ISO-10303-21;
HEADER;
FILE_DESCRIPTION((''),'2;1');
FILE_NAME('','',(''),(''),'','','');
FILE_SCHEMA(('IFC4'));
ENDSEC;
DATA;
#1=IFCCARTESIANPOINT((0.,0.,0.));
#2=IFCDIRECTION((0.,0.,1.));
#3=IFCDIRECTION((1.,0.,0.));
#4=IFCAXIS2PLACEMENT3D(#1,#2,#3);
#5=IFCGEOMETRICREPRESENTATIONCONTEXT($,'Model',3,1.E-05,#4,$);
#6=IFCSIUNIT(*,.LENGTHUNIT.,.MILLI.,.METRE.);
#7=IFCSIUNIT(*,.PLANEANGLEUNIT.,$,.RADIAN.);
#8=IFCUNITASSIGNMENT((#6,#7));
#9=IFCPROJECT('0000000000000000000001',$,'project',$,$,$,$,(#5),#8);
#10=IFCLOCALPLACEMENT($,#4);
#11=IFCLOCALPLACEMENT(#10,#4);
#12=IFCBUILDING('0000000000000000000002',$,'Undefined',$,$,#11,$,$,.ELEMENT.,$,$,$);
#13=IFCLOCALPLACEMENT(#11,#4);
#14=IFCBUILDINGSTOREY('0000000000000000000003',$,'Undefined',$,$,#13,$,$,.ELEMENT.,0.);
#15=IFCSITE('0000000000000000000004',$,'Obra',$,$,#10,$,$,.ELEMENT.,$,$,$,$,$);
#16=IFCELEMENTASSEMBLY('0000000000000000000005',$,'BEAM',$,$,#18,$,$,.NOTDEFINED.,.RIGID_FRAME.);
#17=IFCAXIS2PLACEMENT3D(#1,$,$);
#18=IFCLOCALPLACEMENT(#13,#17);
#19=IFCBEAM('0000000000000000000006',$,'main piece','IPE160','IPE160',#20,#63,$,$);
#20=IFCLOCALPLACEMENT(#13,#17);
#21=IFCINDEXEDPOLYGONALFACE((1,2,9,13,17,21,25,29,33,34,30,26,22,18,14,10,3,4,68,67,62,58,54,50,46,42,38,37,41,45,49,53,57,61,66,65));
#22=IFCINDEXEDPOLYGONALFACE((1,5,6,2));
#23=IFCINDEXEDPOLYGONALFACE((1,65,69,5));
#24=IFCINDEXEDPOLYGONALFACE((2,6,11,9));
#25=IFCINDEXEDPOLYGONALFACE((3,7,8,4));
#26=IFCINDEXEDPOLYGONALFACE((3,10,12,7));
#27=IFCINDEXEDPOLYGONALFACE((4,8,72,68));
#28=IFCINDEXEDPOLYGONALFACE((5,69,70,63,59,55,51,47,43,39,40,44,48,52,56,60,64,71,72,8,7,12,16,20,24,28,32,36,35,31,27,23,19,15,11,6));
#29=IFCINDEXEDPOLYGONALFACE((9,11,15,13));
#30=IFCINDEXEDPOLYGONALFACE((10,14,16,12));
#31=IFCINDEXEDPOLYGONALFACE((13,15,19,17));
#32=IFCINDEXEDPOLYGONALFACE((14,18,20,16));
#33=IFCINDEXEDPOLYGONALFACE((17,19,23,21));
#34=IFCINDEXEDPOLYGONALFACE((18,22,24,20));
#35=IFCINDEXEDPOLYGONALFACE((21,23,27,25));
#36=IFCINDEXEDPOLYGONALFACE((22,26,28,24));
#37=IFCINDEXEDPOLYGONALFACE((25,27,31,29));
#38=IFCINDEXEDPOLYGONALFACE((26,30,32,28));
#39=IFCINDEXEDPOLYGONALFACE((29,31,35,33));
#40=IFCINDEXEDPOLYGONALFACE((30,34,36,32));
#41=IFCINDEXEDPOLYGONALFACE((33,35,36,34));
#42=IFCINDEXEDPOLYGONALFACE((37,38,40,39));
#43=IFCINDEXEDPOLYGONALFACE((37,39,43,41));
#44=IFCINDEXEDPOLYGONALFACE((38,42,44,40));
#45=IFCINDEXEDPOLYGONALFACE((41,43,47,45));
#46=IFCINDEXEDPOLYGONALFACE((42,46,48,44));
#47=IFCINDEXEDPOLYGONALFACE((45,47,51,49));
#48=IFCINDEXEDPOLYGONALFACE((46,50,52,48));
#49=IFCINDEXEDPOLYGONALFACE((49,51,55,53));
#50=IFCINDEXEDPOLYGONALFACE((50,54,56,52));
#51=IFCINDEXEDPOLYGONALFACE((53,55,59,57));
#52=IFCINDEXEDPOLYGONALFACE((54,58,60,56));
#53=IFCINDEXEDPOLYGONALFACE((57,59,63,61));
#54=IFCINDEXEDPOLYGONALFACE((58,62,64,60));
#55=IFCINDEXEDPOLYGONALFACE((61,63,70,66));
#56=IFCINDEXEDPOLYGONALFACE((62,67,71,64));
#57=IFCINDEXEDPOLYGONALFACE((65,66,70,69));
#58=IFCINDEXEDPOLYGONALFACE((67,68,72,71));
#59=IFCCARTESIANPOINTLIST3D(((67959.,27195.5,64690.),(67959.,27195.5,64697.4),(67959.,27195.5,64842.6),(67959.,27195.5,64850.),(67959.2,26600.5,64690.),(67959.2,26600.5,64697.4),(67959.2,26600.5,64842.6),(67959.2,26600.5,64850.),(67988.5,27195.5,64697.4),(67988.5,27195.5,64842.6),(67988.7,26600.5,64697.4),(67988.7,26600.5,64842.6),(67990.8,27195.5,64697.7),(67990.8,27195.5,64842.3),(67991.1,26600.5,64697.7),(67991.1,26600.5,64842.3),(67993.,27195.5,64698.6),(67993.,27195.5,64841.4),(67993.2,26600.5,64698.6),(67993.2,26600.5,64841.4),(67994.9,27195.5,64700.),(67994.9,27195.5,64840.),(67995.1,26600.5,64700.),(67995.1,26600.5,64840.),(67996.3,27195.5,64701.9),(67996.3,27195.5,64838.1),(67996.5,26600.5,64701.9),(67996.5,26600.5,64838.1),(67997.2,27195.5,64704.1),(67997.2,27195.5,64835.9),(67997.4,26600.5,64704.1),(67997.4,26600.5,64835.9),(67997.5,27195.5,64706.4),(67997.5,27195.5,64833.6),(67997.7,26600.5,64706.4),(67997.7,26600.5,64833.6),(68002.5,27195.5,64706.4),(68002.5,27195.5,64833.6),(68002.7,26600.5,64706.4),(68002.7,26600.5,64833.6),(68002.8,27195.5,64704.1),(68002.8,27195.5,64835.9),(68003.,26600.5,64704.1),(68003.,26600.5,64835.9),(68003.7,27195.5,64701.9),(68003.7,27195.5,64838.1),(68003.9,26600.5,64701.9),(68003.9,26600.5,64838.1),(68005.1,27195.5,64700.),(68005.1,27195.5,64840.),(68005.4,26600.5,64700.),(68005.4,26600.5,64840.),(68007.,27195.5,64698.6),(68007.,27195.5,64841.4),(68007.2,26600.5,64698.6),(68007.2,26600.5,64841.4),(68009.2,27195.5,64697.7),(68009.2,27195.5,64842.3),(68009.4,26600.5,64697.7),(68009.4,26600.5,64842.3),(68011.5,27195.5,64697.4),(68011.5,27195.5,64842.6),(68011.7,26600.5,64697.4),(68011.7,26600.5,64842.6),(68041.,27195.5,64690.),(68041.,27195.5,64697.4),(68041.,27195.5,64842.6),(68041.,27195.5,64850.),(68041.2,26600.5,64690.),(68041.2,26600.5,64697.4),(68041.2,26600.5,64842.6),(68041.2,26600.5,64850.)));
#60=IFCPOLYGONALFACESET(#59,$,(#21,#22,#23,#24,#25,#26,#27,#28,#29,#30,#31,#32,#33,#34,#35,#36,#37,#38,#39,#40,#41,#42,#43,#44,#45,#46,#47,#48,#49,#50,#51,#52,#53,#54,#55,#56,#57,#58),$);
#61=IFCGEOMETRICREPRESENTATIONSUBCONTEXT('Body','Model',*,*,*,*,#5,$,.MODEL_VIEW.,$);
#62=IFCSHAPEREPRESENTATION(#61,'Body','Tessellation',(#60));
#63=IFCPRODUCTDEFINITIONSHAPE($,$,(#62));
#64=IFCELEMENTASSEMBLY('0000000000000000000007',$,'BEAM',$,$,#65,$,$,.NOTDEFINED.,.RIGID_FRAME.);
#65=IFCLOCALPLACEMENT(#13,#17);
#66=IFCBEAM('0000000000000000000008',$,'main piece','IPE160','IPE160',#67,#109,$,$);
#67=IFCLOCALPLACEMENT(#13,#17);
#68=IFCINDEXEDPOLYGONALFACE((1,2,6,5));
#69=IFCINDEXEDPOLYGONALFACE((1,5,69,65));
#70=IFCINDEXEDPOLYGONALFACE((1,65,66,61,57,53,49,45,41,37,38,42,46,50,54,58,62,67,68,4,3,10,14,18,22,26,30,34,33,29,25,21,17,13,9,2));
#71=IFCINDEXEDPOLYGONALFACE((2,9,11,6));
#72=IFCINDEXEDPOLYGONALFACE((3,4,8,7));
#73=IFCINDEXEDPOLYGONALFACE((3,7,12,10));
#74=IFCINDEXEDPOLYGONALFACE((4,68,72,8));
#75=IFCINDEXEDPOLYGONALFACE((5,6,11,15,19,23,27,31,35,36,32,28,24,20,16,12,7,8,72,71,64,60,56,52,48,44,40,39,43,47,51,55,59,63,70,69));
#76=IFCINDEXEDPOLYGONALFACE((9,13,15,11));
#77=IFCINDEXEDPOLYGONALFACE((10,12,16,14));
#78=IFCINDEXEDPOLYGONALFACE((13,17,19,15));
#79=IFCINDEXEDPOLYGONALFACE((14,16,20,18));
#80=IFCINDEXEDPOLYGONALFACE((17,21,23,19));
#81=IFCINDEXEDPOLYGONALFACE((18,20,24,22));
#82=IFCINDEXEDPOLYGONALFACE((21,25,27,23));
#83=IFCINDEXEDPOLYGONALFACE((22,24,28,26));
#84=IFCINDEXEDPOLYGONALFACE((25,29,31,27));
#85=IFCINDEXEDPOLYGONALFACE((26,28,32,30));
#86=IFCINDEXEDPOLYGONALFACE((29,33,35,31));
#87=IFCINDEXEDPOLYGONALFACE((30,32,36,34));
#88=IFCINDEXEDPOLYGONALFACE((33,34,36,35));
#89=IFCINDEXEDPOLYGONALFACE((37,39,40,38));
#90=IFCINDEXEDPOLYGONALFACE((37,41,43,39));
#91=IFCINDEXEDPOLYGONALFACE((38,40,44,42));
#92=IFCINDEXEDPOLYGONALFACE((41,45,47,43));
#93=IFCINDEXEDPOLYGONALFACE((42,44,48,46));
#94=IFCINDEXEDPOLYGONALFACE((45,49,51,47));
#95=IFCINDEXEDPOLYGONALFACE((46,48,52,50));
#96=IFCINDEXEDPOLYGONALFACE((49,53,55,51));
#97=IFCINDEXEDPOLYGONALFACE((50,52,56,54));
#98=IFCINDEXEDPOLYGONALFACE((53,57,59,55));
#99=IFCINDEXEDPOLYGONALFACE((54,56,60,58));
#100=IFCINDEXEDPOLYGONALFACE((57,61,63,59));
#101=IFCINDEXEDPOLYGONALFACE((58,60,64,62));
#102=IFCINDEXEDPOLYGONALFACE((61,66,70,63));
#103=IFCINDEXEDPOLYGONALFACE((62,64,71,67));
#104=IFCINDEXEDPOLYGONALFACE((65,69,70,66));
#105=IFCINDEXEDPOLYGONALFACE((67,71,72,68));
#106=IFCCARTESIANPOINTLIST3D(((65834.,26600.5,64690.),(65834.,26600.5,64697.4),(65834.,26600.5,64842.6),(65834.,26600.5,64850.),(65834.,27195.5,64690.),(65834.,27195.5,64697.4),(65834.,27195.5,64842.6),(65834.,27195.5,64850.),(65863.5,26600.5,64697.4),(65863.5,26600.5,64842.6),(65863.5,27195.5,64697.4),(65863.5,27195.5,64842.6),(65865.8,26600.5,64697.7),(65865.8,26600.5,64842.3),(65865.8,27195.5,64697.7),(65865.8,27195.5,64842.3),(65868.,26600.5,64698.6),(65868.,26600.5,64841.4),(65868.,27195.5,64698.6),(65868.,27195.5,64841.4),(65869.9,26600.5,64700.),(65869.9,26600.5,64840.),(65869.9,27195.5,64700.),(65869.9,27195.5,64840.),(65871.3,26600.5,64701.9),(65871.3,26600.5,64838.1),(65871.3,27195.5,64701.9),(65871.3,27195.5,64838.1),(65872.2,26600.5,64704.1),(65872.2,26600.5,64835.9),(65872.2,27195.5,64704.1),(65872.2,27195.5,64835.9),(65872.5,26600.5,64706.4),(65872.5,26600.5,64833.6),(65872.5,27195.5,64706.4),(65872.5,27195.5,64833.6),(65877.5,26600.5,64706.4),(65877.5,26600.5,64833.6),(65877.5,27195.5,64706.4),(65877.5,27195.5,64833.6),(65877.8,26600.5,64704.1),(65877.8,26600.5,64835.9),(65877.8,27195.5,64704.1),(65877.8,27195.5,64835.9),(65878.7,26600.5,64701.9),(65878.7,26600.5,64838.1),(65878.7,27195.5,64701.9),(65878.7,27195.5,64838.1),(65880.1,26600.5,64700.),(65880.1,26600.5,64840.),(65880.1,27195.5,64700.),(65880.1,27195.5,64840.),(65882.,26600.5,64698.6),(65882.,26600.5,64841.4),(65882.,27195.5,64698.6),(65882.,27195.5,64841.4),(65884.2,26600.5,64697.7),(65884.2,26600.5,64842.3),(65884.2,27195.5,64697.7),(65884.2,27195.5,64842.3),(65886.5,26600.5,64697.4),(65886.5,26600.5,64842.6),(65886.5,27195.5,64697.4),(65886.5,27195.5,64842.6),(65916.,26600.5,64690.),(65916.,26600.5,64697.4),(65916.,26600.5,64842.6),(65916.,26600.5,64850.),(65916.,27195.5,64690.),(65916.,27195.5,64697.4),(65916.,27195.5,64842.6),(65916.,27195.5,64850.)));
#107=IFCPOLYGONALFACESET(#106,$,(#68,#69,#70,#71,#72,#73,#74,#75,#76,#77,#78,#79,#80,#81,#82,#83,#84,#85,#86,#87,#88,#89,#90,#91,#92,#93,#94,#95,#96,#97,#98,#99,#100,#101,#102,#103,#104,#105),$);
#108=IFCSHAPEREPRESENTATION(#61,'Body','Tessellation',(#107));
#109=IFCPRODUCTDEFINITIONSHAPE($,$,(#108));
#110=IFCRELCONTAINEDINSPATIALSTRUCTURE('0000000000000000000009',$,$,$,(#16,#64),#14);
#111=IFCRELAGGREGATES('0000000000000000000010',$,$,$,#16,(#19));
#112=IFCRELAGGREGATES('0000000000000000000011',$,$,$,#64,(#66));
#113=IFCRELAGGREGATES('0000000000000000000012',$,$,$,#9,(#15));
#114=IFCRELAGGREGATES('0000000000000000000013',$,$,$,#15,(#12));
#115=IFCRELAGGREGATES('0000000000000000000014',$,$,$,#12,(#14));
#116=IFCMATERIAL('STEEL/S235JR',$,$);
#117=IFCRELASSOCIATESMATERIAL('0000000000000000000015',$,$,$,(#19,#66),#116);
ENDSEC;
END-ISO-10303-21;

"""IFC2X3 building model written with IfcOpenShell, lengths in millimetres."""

from ifc_helpers import new_model, si_unit, frame, origin_with_axes, origin_2d_with_axis, place, context, subcontext, project, spatial, i_section, extrude, material, element, aggregate, save


model = new_model("IFC2X3")

# Units and contexts
model_context = context("Model", 3, precision=1e-05, world=origin_with_axes())
body_context = subcontext(model_context, "Body", "Model", "MODEL_VIEW")
ifc_project = project(units=[si_unit("LENGTHUNIT", "METRE", prefix="MILLI"), si_unit("PLANEANGLEUNIT", "RADIAN")], contexts=[model_context])

# Site, building, storey
site_placement = place(None, origin_with_axes())
site = spatial("IfcSite", under=ifc_project, at=site_placement, Name="Obra", CompositionType="ELEMENT")
building_placement = place(site_placement, origin_with_axes())
building = spatial("IfcBuilding", under=site, at=building_placement, Name="Undefined", CompositionType="ELEMENT")
storey_placement = place(building_placement, origin_with_axes())
storey = spatial("IfcBuildingStorey", under=building, at=storey_placement, Name="Undefined", CompositionType="ELEMENT", Elevation=0.0)

# Element assemblies, beams
ifc_material_1 = material(Name="STEEL/S235JR")
assembly_1_placement = place(storey_placement, origin_with_axes())
assembly_1 = element("IfcElementAssembly", 1, at=assembly_1_placement, inside=storey, Name="BEAM", AssemblyPlace="NOTDEFINED", PredefinedType="RIGID_FRAME")
beam_1_placement = place(assembly_1_placement, frame((68000.2, 26600.5, 64770.0), z_axis=(0.0, 0.0, 1.0), x_axis=(-0.000391, 1.0, 0.0)))
beam_1 = element("IfcBeam", 2, at=beam_1_placement, material=ifc_material_1, Name="main piece", Description="IPE160", ObjectType="IPE160", context=body_context, shape_type="SweptSolid", body=[
    extrude(i_section(OverallWidth=82.0, OverallDepth=160.0, WebThickness=5.0, FlangeThickness=7.4, FilletRadius=9.0, at=origin_2d_with_axis()), frame((595.0, 0.0, 0.0), z_axis=(-1.0, 0.0, 0.0), x_axis=(0.0, -1.0, 0.0)), (0.0, 0.0, 1.0), 595.0),
])
aggregate(assembly_1, [beam_1])
assembly_2_placement = place(storey_placement, origin_with_axes())
assembly_2 = element("IfcElementAssembly", 3, at=assembly_2_placement, inside=storey, Name="BEAM", AssemblyPlace="NOTDEFINED", PredefinedType="RIGID_FRAME")
beam_2_placement = place(assembly_2_placement, frame((65875.0, 26600.5, 64770.0), z_axis=(0.0, 0.0, 1.0), x_axis=(0.0, 1.0, 0.0)))
beam_2 = element("IfcBeam", 4, at=beam_2_placement, material=ifc_material_1, Name="main piece", Description="IPE160", ObjectType="IPE160", context=body_context, shape_type="SweptSolid", body=[
    extrude(i_section(OverallWidth=82.0, OverallDepth=160.0, WebThickness=5.0, FlangeThickness=7.4, FilletRadius=9.0, at=origin_2d_with_axis()), frame((595.1, 0.0, 0.0), z_axis=(-1.0, 0.0, 0.0), x_axis=(0.0, -1.0, 0.0)), (0.0, 0.0, 1.0), 595.0),
])
aggregate(assembly_2, [beam_2])

save(model, "model.ifc")
